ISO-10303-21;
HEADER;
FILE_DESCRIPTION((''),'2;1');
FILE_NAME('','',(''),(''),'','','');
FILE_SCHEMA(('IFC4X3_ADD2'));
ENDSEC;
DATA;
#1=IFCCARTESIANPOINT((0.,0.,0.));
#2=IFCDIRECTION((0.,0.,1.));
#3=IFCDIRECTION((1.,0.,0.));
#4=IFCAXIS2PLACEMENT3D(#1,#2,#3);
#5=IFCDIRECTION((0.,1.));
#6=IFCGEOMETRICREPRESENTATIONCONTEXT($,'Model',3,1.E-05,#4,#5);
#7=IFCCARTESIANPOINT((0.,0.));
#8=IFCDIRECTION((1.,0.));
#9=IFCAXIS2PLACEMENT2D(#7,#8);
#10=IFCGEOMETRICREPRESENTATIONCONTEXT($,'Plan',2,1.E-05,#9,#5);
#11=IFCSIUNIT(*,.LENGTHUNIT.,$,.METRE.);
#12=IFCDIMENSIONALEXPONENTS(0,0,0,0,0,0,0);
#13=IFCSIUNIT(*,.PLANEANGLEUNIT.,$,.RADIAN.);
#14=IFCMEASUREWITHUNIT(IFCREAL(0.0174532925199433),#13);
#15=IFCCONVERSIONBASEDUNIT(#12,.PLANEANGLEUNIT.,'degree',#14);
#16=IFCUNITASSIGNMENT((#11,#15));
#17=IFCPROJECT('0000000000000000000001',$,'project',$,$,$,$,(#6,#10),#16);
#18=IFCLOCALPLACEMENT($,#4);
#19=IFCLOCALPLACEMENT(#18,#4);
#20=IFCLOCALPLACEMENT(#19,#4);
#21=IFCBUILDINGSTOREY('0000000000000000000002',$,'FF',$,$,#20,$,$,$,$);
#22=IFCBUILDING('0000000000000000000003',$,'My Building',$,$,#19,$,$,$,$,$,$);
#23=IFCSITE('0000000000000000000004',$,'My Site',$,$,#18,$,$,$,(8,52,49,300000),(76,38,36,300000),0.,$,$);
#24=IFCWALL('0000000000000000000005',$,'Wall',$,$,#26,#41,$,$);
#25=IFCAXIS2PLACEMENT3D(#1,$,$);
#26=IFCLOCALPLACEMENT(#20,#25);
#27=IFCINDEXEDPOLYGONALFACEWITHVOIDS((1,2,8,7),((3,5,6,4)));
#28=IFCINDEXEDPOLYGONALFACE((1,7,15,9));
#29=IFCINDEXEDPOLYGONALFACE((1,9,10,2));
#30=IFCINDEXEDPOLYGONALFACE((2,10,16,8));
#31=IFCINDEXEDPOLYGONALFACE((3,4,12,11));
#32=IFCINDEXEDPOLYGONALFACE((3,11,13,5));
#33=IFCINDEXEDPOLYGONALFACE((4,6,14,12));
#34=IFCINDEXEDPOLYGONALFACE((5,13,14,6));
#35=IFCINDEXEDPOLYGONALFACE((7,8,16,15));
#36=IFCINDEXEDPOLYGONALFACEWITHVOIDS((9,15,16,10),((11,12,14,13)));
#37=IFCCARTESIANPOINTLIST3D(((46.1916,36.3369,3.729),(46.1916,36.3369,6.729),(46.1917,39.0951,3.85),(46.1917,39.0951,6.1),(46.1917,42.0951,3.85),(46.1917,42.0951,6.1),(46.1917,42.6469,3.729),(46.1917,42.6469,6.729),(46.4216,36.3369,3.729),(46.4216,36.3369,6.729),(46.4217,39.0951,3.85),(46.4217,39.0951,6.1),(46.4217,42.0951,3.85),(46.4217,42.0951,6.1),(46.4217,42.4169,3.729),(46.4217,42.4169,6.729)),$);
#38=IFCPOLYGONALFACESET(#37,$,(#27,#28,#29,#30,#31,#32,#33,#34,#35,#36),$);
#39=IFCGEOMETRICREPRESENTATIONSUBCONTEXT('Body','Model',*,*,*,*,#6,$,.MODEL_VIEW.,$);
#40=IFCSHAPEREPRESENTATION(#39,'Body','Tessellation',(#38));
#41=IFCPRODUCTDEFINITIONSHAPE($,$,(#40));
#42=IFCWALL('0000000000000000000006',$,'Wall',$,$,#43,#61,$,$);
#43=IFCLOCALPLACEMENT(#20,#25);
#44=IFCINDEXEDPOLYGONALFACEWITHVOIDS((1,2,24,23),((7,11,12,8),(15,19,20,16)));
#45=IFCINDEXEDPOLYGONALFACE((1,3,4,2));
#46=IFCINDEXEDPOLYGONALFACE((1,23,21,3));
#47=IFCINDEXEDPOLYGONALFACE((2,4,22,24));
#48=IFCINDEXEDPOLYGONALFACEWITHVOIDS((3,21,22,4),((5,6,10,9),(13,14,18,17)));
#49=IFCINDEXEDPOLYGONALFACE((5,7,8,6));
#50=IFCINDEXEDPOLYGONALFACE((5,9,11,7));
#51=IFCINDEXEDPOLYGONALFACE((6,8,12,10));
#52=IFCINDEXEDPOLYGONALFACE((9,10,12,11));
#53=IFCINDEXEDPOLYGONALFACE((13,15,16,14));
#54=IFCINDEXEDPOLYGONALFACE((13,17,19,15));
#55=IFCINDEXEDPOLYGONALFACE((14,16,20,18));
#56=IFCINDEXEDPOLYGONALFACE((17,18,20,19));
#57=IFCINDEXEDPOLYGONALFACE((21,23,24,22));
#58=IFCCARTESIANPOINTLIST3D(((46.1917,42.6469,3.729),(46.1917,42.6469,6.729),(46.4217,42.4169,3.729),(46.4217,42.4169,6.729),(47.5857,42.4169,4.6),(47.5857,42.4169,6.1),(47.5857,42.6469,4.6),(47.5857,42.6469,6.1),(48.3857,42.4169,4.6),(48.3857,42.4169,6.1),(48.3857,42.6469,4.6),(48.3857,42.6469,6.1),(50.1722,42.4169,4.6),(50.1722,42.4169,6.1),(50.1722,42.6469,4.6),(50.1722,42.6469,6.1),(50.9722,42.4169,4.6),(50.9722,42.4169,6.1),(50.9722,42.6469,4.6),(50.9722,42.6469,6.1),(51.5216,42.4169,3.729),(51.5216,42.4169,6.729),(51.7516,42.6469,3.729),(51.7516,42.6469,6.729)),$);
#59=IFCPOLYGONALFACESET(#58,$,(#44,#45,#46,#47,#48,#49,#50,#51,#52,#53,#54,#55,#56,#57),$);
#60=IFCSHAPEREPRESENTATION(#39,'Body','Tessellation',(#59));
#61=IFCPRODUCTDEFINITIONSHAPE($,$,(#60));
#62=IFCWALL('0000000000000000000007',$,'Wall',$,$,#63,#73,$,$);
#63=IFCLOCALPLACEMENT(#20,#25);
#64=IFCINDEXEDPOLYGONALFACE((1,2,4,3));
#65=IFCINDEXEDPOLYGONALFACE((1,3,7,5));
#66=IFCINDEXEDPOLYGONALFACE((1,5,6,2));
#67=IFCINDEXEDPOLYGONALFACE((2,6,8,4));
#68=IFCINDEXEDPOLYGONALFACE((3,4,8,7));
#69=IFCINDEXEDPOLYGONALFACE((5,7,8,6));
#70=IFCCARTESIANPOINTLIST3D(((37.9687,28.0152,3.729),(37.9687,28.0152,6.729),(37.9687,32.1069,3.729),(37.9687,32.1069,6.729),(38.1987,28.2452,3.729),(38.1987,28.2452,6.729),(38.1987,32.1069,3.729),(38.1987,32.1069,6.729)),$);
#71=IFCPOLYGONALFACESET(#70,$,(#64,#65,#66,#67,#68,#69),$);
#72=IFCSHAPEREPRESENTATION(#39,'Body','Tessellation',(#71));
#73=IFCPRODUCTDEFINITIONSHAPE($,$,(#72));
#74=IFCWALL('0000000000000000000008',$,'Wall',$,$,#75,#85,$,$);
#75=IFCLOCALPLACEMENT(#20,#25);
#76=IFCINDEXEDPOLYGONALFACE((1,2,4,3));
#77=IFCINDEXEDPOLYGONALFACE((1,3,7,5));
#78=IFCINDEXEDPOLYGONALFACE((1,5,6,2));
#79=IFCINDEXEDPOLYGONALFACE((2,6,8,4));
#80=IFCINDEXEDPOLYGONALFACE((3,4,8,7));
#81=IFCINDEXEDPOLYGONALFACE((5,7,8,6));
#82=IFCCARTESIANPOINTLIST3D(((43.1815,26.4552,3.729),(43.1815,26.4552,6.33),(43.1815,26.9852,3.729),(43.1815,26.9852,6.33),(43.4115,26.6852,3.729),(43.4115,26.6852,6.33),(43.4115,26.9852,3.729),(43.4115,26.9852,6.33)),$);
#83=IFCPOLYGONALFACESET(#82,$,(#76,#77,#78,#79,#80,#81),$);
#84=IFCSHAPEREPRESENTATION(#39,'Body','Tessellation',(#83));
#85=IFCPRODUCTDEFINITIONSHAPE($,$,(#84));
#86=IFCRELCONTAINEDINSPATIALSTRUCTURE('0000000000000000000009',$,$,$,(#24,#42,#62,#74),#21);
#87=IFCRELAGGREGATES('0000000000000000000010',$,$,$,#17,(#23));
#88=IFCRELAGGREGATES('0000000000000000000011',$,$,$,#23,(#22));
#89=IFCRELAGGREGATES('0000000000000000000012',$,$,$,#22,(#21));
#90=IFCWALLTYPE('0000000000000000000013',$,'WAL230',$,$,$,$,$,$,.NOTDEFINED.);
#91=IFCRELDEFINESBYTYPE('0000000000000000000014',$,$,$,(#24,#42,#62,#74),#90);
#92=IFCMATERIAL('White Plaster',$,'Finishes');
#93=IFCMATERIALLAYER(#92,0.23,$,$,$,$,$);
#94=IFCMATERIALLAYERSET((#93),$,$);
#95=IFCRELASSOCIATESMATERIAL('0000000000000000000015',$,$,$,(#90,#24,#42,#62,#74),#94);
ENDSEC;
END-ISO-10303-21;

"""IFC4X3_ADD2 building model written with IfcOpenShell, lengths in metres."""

from ifc_helpers import new_model, entity, si_unit, converted_unit, direction, frame, origin_with_axes, origin_2d_with_axis, place, context, subcontext, project, spatial, line, indexed_curve, outline, extrude, source, transform, mapped, material, layer, layer_set, layer_usage, type_object, element, save


model = new_model("IFC4X3_ADD2")

# Units and contexts
model_context = context("Model", 3, precision=1e-05, world=origin_with_axes(), true_north=direction((0.0, 1.0)))
plan_context = context("Plan", 2, precision=1e-05, world=origin_2d_with_axis(), true_north=direction((0.0, 1.0)))
body_context = subcontext(model_context, "Body", "Model", "MODEL_VIEW")
ifc_project = project(units=[si_unit("LENGTHUNIT", "METRE"), converted_unit("PLANEANGLEUNIT", "degree", entity("IfcReal", 0.0174532925199433), si_unit("PLANEANGLEUNIT", "RADIAN"), dimensions=[0, 0, 0, 0, 0, 0, 0])], contexts=[model_context, plan_context])

# Site, building, storey
site_placement = place(None, origin_with_axes())
site = spatial("IfcSite", under=ifc_project, at=site_placement, Name="My Site", RefLatitude=(8, 52, 49, 300000), RefLongitude=(76, 38, 36, 300000), RefElevation=0.0)
building_placement = place(site_placement, origin_with_axes())
building = spatial("IfcBuilding", under=site, at=building_placement, Name="My Building")
storey_placement = place(building_placement, origin_with_axes())
storey = spatial("IfcBuildingStorey", under=building, at=storey_placement, Name="FF")

# Wall, opening
ifc_material_1 = material(Name="White Plaster", Category="Finishes")
ifc_layer_1 = layer(ifc_material_1, 0.23)
ifc_layer_set_1 = layer_set([ifc_layer_1])
ifc_layer_usage_1 = layer_usage(ifc_layer_set_1, "AXIS2", "POSITIVE", 0.0)
wall_type_1 = type_object("IfcWallType", Name="WAL230", PredefinedType="NOTDEFINED", material=ifc_layer_set_1)
wall_1_placement = place(storey_placement, frame((46.4216, 36.3369, 3.729), z_axis=(0.0, 0.0, 1.0), x_axis=(0.0, 1.0, 0.0)))
wall_1 = element("IfcWall", 1, at=wall_1_placement, inside=storey, type_object=wall_type_1, material=ifc_layer_usage_1, Name="Wall", context=body_context, shape_type="SweptSolid", body=[
    extrude(outline(indexed_curve([(0.0, 0.0), (0.0, 0.23), (6.31, 0.23), (6.08, 0.0)], segments=[line(1, 2, 3, 4, 1)])), origin_with_axes(), (0.0, 0.0, 1.0), 3.0),
])
shared_shape_1 = source(origin_with_axes(), body_context, "Body", "SweptSolid", [
    extrude(outline(indexed_curve([(0.0, 0.0), (3.0, 0.0), (3.0, 2.25), (0.0, 2.25)], segments=[line(1, 2, 3, 4, 1)])), frame((0.0, -0.6, 0.0), z_axis=(0.0, -1.0, 0.0), x_axis=(1.0, 0.0, 0.0)), (0.0, 0.0, -1.0), 1.2),
])
opening_1_placement = place(wall_1_placement, frame((2.7582, 0.0, 0.121), z_axis=(0.0, 0.0, 1.0), x_axis=(1.0, 0.0, 0.0)))
element("IfcOpeningElement", 2, at=opening_1_placement, cuts=wall_1, PredefinedType="OPENING", context=body_context, shape_type="MappedRepresentation", body=[
    mapped(shared_shape_1, transform((0.0, 0.0, 0.0), x_axis=(1.0, 0.0, 0.0), y_axis=(0.0, 1.0, 0.0), z_axis=(0.0, 0.0, 1.0), scale=1.0)),
])

# Wall, openings
ifc_layer_usage_2 = layer_usage(ifc_layer_set_1, "AXIS2", "POSITIVE", 0.0)
wall_2_placement = place(storey_placement, frame((51.7516, 42.6469, 3.729), z_axis=(0.0, 0.0, 1.0), x_axis=(-1.0, 0.0, 0.0)))
wall_2 = element("IfcWall", 3, at=wall_2_placement, inside=storey, type_object=wall_type_1, material=ifc_layer_usage_2, Name="Wall", context=body_context, shape_type="SweptSolid", body=[
    extrude(outline(indexed_curve([(0.0, 0.0), (0.23, 0.23), (5.33, 0.23), (5.56, 0.0)], segments=[line(1, 2, 3, 4, 1)])), origin_with_axes(), (0.0, 0.0, 1.0), 3.0),
])
shared_shape_2 = source(origin_with_axes(), body_context, "Body", "SweptSolid", [
    extrude(outline(indexed_curve([(0.0, 0.0), (0.8, 0.0), (0.8, 1.5), (0.0, 1.5)], segments=[line(1, 2, 3, 4, 1)])), frame((0.0, -0.6, 0.0), z_axis=(0.0, -1.0, 0.0), x_axis=(1.0, 0.0, 0.0)), (0.0, 0.0, -1.0), 1.2),
])
opening_2_placement = place(wall_2_placement, frame((1.5795, 0.25, 0.871), z_axis=(0.0, 0.0, 1.0), x_axis=(-1.0, 0.0, 0.0)))
element("IfcOpeningElement", 4, at=opening_2_placement, cuts=wall_2, PredefinedType="OPENING", context=body_context, shape_type="MappedRepresentation", body=[
    mapped(shared_shape_2, transform((0.0, 0.0, 0.0), x_axis=(1.0, 0.0, 0.0), y_axis=(0.0, 1.0, 0.0), z_axis=(0.0, 0.0, 1.0), scale=1.0)),
])
opening_3_placement = place(wall_2_placement, frame((4.1659, 0.23, 0.871), z_axis=(0.0, 0.0, 1.0), x_axis=(-1.0, 0.0, 0.0)))
element("IfcOpeningElement", 5, at=opening_3_placement, cuts=wall_2, PredefinedType="OPENING", context=body_context, shape_type="MappedRepresentation", body=[
    mapped(shared_shape_2, transform((0.0, 0.0, 0.0), x_axis=(1.0, 0.0, 0.0), y_axis=(0.0, 1.0, 0.0), z_axis=(0.0, 0.0, 1.0), scale=1.0)),
])

# Walls
ifc_layer_usage_3 = layer_usage(ifc_layer_set_1, "AXIS2", "POSITIVE", 0.0)
wall_3_placement = place(storey_placement, frame((38.1987, 28.2452, 3.729), z_axis=(0.0, 0.0, 1.0), x_axis=(0.0, 1.0, 0.0)))
element("IfcWall", 6, at=wall_3_placement, inside=storey, type_object=wall_type_1, material=ifc_layer_usage_3, Name="Wall", context=body_context, shape_type="SweptSolid", body=[
    extrude(outline(indexed_curve([(0.0, 0.0), (-0.23, 0.23), (3.8617, 0.23), (3.8617, 0.0)], segments=[line(1, 2, 3, 4, 1)])), origin_with_axes(), (0.0, 0.0, 1.0), 3.0),
])
ifc_layer_usage_4 = layer_usage(ifc_layer_set_1, "AXIS2", "POSITIVE", 0.0)
wall_4_placement = place(storey_placement, frame((43.4115, 26.6852, 3.729), z_axis=(0.0, 0.0, 1.0), x_axis=(0.0, 1.0, 0.0)))
element("IfcWall", 7, at=wall_4_placement, inside=storey, type_object=wall_type_1, material=ifc_layer_usage_4, Name="Wall", context=body_context, shape_type="SweptSolid", body=[
    extrude(outline(indexed_curve([(0.0, 0.0), (-0.23, 0.23), (0.3, 0.23), (0.3, 0.0)], segments=[line(1, 2, 3, 4, 1)])), origin_with_axes(), (0.0, 0.0, 1.0), 2.601),
])

save(model, "model.ifc")
